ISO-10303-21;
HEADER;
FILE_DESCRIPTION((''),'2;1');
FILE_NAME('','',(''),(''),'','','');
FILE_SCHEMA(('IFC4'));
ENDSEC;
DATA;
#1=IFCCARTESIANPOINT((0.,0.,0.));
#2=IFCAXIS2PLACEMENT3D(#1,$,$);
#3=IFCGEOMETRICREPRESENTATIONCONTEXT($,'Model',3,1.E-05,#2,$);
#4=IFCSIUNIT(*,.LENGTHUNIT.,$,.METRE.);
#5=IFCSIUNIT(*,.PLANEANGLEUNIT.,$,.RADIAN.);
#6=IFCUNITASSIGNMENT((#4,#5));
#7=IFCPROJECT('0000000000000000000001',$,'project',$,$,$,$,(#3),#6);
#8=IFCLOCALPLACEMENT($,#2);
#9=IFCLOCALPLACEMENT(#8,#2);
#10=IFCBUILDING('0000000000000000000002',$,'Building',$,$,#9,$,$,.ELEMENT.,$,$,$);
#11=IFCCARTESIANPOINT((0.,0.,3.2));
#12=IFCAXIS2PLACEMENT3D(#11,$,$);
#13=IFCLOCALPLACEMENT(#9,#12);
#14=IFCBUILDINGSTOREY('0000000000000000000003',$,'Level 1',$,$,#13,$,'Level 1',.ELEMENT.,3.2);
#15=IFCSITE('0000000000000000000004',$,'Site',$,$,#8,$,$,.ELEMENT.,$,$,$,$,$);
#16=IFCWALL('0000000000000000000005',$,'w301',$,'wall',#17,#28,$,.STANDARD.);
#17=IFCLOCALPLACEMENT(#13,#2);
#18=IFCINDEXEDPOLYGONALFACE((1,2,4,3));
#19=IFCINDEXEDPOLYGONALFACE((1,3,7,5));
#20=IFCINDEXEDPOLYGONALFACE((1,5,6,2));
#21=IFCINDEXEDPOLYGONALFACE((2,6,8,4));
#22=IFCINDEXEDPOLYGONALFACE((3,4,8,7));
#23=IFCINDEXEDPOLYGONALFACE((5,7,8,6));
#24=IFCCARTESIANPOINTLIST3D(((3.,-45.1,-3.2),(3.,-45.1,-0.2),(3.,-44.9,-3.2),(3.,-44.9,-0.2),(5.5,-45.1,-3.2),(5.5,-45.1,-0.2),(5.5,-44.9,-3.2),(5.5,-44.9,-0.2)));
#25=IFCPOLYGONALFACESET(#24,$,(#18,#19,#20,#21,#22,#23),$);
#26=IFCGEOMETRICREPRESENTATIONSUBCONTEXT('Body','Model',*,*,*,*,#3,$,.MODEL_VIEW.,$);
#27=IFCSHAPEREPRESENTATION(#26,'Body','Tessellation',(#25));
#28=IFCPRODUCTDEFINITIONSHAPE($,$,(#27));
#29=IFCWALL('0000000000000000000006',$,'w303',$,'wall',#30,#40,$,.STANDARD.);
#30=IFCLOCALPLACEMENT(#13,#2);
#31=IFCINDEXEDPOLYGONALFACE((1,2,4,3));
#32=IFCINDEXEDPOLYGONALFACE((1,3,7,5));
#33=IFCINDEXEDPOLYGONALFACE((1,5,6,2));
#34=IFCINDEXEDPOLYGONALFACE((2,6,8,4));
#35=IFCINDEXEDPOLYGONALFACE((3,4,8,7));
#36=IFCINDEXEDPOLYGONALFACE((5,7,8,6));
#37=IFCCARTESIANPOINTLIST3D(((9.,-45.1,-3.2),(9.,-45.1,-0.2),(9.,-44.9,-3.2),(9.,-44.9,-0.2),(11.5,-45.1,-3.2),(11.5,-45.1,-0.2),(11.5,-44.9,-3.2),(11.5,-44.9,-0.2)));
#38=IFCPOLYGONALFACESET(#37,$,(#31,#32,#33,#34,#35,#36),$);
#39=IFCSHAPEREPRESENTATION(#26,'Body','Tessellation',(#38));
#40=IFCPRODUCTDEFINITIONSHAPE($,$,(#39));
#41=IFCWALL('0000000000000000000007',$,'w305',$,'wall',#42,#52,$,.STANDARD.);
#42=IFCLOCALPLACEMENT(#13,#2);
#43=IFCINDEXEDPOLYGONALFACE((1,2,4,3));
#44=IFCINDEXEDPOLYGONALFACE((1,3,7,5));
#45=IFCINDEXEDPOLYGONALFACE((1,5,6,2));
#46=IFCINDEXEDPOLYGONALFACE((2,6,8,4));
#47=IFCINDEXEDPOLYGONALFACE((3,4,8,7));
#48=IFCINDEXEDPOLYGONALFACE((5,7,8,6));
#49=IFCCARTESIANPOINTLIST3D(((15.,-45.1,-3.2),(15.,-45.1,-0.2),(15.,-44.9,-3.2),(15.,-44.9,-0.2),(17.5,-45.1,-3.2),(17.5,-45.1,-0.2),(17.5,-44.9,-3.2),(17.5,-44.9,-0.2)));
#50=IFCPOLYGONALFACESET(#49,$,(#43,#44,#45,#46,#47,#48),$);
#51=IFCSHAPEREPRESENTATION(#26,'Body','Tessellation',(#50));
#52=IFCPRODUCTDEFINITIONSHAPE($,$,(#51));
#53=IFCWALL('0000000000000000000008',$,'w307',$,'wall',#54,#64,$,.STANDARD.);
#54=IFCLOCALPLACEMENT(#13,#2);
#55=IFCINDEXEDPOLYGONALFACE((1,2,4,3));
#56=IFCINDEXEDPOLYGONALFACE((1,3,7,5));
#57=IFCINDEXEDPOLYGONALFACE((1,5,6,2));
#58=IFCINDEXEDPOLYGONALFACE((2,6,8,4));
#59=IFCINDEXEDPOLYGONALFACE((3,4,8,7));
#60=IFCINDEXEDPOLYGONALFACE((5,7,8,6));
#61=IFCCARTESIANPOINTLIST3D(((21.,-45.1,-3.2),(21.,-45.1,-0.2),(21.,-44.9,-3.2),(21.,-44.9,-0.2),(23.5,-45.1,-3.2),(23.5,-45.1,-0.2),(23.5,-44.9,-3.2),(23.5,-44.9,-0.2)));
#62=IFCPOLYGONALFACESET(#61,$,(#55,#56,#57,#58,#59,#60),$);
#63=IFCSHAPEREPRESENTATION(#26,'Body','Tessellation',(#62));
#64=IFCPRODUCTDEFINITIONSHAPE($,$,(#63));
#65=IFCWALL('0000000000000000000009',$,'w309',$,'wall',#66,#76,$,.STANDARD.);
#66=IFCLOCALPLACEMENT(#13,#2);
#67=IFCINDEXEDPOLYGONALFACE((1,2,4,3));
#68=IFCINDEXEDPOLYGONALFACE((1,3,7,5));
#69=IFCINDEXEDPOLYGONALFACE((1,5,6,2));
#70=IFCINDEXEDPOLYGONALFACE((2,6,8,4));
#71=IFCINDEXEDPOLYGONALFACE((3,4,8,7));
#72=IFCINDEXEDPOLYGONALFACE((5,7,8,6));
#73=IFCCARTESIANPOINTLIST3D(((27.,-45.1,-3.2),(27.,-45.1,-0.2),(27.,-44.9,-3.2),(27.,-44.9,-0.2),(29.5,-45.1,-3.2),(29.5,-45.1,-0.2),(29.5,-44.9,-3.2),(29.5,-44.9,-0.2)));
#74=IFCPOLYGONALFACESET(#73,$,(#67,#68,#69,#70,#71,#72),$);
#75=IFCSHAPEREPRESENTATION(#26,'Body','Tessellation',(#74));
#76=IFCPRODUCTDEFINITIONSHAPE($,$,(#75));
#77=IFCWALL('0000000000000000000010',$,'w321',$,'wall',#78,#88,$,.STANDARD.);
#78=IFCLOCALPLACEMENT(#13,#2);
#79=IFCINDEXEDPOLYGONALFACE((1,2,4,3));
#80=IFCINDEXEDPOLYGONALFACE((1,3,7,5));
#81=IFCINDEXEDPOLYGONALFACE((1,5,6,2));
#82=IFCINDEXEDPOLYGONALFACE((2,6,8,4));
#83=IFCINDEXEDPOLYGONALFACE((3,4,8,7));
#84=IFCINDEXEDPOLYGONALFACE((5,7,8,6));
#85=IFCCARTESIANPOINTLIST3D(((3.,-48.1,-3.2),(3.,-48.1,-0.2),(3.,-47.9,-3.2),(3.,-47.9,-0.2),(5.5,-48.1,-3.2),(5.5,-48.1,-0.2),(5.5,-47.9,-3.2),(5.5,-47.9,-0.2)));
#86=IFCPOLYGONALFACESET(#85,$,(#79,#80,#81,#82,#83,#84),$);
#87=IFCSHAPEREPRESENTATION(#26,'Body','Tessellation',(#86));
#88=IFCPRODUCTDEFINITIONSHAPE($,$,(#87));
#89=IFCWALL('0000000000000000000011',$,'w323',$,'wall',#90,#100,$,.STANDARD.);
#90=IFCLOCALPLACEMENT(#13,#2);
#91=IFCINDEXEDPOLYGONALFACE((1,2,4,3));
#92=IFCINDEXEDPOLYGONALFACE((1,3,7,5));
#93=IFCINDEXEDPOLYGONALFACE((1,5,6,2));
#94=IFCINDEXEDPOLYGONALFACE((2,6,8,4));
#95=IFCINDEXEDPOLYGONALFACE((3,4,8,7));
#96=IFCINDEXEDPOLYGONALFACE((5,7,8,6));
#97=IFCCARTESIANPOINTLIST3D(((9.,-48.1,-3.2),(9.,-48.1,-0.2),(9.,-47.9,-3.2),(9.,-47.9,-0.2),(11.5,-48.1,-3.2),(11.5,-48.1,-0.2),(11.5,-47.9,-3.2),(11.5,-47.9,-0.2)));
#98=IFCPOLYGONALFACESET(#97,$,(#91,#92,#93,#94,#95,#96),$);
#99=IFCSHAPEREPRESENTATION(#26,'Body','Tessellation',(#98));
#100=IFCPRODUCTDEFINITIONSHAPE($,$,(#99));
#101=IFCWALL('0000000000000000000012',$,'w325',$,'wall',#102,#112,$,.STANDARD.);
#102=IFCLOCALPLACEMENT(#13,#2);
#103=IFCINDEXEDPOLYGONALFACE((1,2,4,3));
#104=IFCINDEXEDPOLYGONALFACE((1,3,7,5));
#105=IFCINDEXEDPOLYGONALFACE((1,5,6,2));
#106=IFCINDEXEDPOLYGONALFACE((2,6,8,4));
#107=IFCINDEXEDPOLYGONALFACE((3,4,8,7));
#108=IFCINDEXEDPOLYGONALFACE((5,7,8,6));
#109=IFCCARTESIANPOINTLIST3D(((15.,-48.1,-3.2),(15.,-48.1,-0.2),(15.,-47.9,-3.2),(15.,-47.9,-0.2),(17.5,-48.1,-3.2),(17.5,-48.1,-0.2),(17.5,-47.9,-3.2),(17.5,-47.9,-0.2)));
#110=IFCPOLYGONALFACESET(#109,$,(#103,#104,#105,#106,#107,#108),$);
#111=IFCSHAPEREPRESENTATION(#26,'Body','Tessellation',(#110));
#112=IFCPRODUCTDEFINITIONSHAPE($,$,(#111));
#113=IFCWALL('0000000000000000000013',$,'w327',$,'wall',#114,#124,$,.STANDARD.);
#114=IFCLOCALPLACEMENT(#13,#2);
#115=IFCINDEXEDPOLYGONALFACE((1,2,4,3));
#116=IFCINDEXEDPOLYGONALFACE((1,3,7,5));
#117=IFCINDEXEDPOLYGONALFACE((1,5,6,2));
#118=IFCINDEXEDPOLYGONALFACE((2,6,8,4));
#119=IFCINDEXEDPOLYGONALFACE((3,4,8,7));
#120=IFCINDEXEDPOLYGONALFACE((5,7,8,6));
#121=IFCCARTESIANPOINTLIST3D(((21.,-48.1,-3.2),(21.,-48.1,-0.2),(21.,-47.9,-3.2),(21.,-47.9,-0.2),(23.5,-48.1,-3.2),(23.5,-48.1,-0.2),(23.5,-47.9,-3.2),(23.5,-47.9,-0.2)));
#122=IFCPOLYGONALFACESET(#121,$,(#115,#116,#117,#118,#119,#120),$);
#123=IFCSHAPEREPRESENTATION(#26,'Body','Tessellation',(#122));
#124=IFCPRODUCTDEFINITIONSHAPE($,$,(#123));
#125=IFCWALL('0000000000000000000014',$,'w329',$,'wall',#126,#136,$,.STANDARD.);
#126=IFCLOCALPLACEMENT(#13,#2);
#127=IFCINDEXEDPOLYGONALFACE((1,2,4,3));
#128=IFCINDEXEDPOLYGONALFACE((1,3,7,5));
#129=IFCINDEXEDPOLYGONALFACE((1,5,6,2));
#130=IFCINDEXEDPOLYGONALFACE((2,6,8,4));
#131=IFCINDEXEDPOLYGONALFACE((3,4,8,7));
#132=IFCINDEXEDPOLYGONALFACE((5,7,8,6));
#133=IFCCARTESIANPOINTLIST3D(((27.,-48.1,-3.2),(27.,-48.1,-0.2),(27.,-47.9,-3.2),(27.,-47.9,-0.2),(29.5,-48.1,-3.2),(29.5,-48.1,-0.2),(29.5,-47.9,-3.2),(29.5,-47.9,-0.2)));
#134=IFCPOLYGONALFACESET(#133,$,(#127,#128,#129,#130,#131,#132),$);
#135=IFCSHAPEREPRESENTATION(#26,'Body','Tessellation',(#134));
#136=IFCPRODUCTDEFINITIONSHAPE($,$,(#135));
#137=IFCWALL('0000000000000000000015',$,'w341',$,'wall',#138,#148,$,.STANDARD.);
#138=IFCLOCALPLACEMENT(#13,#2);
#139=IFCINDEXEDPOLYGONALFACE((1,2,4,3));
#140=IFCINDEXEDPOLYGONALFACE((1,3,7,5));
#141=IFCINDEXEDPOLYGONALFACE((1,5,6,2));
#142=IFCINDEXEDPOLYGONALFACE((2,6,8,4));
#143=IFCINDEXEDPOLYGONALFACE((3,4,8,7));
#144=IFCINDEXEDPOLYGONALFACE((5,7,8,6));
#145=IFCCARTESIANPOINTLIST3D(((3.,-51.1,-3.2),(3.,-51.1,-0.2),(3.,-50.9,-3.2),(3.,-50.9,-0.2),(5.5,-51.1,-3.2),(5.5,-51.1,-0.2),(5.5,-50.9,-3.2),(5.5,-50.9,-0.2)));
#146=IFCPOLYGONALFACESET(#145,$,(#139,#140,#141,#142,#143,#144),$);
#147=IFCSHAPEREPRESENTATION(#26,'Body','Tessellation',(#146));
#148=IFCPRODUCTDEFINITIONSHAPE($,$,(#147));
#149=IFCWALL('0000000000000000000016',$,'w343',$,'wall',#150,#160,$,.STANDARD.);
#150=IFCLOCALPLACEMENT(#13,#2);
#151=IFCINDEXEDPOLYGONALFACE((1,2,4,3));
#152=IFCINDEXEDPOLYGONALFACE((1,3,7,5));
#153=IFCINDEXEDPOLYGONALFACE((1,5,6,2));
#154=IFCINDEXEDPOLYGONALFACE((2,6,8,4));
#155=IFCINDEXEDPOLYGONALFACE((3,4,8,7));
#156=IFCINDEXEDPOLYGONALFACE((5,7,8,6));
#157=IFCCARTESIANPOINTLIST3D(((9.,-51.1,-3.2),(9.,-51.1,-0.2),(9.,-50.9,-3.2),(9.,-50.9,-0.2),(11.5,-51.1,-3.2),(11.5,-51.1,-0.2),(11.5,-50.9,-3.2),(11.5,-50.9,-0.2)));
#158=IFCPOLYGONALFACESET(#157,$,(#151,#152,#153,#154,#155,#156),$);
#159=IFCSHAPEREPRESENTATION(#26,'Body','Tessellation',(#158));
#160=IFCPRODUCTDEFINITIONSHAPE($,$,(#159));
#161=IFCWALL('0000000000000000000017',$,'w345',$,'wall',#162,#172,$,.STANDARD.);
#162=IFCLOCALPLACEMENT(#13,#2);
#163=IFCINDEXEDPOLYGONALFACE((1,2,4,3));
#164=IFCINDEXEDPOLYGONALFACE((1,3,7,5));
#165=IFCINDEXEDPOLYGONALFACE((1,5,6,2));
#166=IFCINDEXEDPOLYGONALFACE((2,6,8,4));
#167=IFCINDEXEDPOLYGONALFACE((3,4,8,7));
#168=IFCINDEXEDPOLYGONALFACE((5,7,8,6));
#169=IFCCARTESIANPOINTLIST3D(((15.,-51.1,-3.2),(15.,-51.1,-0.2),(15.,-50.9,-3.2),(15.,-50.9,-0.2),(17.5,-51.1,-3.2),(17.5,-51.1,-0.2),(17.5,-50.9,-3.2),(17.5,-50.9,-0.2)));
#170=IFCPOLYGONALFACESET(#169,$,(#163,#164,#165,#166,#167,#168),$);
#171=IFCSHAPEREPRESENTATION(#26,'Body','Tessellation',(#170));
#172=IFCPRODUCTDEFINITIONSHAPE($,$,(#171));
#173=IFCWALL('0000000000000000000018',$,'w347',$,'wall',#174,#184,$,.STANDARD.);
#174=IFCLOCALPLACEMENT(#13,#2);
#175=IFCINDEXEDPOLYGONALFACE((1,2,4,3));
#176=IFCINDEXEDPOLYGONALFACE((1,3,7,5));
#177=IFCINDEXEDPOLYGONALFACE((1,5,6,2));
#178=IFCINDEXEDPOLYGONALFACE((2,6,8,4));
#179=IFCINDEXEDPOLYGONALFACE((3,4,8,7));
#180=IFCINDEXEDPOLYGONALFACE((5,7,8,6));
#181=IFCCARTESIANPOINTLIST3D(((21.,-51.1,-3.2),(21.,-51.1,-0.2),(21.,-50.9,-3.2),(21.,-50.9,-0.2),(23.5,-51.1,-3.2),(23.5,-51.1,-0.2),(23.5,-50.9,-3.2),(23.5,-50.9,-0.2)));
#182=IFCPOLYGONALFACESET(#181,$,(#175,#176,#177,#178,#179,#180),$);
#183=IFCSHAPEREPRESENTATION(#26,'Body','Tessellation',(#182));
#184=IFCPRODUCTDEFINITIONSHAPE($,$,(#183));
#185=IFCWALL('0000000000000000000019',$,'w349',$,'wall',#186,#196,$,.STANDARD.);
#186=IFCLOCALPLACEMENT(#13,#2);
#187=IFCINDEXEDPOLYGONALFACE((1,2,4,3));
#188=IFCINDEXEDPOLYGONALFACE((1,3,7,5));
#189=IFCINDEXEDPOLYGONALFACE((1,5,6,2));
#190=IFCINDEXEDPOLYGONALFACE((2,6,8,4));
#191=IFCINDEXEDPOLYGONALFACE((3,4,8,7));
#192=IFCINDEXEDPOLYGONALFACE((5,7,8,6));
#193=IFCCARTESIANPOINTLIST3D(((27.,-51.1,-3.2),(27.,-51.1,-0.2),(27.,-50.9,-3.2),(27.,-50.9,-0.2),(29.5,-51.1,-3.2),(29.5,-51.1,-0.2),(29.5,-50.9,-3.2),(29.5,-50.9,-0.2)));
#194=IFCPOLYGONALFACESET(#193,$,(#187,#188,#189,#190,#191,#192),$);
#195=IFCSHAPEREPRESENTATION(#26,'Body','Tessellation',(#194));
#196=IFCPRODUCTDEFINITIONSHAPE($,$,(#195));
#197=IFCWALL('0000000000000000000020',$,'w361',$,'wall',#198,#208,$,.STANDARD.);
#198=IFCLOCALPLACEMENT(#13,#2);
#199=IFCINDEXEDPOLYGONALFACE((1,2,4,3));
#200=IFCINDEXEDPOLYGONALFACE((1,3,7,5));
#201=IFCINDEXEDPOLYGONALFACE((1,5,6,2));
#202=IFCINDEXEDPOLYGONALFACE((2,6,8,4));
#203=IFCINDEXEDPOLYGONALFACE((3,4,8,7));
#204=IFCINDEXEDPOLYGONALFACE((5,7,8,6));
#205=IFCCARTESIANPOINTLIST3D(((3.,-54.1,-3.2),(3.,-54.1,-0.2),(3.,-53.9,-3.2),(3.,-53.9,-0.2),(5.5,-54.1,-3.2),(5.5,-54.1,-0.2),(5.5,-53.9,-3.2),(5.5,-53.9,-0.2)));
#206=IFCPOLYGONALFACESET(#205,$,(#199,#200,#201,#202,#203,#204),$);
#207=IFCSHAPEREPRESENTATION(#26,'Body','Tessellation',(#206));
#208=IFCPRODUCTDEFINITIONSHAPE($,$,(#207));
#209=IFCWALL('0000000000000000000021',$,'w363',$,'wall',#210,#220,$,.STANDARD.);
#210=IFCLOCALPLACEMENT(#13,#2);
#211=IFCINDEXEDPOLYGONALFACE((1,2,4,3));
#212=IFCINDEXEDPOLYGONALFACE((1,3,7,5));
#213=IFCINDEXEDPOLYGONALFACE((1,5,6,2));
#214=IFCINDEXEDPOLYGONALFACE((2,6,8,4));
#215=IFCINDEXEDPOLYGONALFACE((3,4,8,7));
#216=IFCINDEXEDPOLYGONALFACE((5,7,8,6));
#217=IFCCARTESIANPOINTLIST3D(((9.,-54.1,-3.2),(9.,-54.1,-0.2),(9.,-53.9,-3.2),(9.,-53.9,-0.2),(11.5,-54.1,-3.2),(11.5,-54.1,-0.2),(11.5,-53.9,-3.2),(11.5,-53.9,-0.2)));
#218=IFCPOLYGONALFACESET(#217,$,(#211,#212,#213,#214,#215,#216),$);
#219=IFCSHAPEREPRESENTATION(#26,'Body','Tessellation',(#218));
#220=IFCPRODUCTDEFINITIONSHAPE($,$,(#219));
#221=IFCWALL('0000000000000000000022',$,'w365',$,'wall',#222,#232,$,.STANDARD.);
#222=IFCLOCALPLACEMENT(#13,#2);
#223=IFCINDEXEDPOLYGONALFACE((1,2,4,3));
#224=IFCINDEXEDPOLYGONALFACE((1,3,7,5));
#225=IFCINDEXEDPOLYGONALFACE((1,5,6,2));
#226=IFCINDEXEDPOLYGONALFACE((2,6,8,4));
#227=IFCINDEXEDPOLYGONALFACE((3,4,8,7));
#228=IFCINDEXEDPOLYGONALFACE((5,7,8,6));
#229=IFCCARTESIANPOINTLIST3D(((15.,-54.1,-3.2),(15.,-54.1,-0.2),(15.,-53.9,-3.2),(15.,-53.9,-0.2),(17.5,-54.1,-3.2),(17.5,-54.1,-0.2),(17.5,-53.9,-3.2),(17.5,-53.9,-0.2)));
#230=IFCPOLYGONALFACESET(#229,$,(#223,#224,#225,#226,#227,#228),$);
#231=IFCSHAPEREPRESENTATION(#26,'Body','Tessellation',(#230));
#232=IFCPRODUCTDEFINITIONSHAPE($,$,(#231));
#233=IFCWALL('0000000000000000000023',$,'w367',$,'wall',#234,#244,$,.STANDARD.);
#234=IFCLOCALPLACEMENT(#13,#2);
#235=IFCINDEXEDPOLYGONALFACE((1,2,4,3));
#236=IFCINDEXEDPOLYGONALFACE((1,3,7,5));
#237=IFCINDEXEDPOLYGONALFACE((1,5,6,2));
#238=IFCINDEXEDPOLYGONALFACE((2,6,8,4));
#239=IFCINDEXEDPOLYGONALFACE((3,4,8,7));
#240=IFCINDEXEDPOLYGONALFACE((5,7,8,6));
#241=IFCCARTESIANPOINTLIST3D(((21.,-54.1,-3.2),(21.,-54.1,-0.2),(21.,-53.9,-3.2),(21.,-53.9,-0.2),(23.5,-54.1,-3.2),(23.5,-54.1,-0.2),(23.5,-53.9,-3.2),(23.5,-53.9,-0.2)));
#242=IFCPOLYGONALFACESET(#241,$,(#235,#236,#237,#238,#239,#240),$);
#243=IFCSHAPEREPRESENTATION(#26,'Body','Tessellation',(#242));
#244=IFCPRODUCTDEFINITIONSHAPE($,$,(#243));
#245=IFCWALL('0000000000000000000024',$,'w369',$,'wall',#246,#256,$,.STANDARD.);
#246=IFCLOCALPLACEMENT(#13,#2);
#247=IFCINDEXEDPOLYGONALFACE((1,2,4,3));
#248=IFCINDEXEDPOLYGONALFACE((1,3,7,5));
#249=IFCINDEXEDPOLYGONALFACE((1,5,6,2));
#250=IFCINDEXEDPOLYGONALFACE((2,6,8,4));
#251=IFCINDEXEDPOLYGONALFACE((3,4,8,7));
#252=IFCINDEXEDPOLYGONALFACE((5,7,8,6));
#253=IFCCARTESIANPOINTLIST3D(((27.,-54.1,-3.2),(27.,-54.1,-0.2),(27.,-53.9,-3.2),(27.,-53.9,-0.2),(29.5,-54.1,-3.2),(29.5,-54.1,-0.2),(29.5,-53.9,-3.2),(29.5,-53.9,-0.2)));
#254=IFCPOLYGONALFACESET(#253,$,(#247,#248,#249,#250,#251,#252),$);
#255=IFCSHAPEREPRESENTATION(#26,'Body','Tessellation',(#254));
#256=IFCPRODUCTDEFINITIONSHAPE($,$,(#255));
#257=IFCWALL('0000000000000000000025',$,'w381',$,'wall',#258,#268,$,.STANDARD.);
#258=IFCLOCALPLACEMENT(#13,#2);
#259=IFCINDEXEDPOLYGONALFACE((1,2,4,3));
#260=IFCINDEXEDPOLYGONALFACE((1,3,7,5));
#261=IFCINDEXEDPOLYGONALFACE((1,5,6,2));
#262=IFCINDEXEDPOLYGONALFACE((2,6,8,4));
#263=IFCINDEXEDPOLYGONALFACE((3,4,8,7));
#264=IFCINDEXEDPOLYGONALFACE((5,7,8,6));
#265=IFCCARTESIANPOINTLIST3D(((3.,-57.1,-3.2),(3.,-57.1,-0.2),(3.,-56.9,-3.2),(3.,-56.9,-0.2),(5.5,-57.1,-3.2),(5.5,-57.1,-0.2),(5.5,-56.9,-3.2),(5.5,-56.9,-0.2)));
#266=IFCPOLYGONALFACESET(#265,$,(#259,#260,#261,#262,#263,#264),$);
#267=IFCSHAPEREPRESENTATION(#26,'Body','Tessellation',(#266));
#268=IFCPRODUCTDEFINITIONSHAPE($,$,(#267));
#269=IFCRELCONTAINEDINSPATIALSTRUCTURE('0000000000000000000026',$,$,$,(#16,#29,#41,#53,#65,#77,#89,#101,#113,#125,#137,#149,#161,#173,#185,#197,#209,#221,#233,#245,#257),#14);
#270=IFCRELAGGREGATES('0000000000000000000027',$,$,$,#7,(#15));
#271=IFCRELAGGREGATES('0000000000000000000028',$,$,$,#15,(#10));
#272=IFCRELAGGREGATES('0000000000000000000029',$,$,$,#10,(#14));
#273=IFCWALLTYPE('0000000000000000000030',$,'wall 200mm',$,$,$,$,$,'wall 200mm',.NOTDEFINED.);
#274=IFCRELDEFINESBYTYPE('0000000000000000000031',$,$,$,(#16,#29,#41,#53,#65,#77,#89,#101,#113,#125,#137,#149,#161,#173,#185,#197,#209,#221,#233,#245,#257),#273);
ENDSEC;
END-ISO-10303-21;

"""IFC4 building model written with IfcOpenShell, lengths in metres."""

from ifc_helpers import new_model, si_unit, frame, frame_2d, origin, place, context, subcontext, project, spatial, rectangle, extrude, type_object, element, save


model = new_model("IFC4")

# Units and contexts
model_context = context("Model", 3, precision=1e-05, world=origin())
body_context = subcontext(model_context, "Body", "Model", "MODEL_VIEW")
ifc_project = project(units=[si_unit("LENGTHUNIT", "METRE"), si_unit("PLANEANGLEUNIT", "RADIAN")], contexts=[model_context])

# Site, building, storey
site_placement = place(None, origin())
site = spatial("IfcSite", under=ifc_project, at=site_placement, Name="Site", CompositionType="ELEMENT")
building_placement = place(site_placement, origin())
building = spatial("IfcBuilding", under=site, at=building_placement, Name="Building", CompositionType="ELEMENT")
storey_placement = place(building_placement, frame((0.0, 0.0, 3.2)))
storey = spatial("IfcBuildingStorey", under=building, at=storey_placement, Name="Level 1", LongName="Level 1", CompositionType="ELEMENT", Elevation=3.2)

# Walls
wall_type = type_object("IfcWallType", Name="wall 200mm", ElementType="wall 200mm", PredefinedType="NOTDEFINED")
for number, where, z_axis, x_axis, name in (
    (1, (3.0, -45.0, -3.2), (0.0, 0.0, 1.0), (1.0, 0.0, 0.0), "w301"),
    (2, (9.0, -45.0, -3.2), (0.0, 0.0, 1.0), (1.0, 0.0, 0.0), "w303"),
    (3, (15.0, -45.0, -3.2), (0.0, 0.0, 1.0), (1.0, 0.0, 0.0), "w305"),
    (4, (21.0, -45.0, -3.2), (0.0, 0.0, 1.0), (1.0, 0.0, 0.0), "w307"),
    (5, (27.0, -45.0, -3.2), (0.0, 0.0, 1.0), (1.0, 0.0, 0.0), "w309"),
    (6, (3.0, -48.0, -3.2), (0.0, 0.0, 1.0), (1.0, 0.0, 0.0), "w321"),
    (7, (9.0, -48.0, -3.2), (0.0, 0.0, 1.0), (1.0, 0.0, 0.0), "w323"),
    (8, (15.0, -48.0, -3.2), (0.0, 0.0, 1.0), (1.0, 0.0, 0.0), "w325"),
    (9, (21.0, -48.0, -3.2), (0.0, 0.0, 1.0), (1.0, 0.0, 0.0), "w327"),
    (10, (27.0, -48.0, -3.2), (0.0, 0.0, 1.0), (1.0, 0.0, 0.0), "w329"),
    (11, (3.0, -51.0, -3.2), (0.0, 0.0, 1.0), (1.0, 0.0, 0.0), "w341"),
    (12, (9.0, -51.0, -3.2), (0.0, 0.0, 1.0), (1.0, 0.0, 0.0), "w343"),
    (13, (15.0, -51.0, -3.2), (0.0, 0.0, 1.0), (1.0, 0.0, 0.0), "w345"),
    (14, (21.0, -51.0, -3.2), (0.0, 0.0, 1.0), (1.0, 0.0, 0.0), "w347"),
    (15, (27.0, -51.0, -3.2), (0.0, 0.0, 1.0), (1.0, 0.0, 0.0), "w349"),
    (16, (3.0, -54.0, -3.2), (0.0, 0.0, 1.0), (1.0, 0.0, 0.0), "w361"),
    (17, (9.0, -54.0, -3.2), (0.0, 0.0, 1.0), (1.0, 0.0, 0.0), "w363"),
    (18, (15.0, -54.0, -3.2), (0.0, 0.0, 1.0), (1.0, 0.0, 0.0), "w365"),
    (19, (21.0, -54.0, -3.2), (0.0, 0.0, 1.0), (1.0, 0.0, 0.0), "w367"),
    (20, (27.0, -54.0, -3.2), (0.0, 0.0, 1.0), (1.0, 0.0, 0.0), "w369"),
    (21, (3.0, -57.0, -3.2), (0.0, 0.0, 1.0), (1.0, 0.0, 0.0), "w381"),
):
    element("IfcWall", number, at=place(storey_placement, frame(where, z_axis=z_axis, x_axis=x_axis)), inside=storey, type_object=wall_type, Name=name, ObjectType="wall", PredefinedType="STANDARD", context=body_context, shape_type="SweptSolid", body=[
        extrude(rectangle(XDim=2.5, YDim=0.2, at=frame_2d((1.25, 0.0))), origin(), (0.0, 0.0, 1.0), 3.0),
    ])

save(model, "model.ifc")
